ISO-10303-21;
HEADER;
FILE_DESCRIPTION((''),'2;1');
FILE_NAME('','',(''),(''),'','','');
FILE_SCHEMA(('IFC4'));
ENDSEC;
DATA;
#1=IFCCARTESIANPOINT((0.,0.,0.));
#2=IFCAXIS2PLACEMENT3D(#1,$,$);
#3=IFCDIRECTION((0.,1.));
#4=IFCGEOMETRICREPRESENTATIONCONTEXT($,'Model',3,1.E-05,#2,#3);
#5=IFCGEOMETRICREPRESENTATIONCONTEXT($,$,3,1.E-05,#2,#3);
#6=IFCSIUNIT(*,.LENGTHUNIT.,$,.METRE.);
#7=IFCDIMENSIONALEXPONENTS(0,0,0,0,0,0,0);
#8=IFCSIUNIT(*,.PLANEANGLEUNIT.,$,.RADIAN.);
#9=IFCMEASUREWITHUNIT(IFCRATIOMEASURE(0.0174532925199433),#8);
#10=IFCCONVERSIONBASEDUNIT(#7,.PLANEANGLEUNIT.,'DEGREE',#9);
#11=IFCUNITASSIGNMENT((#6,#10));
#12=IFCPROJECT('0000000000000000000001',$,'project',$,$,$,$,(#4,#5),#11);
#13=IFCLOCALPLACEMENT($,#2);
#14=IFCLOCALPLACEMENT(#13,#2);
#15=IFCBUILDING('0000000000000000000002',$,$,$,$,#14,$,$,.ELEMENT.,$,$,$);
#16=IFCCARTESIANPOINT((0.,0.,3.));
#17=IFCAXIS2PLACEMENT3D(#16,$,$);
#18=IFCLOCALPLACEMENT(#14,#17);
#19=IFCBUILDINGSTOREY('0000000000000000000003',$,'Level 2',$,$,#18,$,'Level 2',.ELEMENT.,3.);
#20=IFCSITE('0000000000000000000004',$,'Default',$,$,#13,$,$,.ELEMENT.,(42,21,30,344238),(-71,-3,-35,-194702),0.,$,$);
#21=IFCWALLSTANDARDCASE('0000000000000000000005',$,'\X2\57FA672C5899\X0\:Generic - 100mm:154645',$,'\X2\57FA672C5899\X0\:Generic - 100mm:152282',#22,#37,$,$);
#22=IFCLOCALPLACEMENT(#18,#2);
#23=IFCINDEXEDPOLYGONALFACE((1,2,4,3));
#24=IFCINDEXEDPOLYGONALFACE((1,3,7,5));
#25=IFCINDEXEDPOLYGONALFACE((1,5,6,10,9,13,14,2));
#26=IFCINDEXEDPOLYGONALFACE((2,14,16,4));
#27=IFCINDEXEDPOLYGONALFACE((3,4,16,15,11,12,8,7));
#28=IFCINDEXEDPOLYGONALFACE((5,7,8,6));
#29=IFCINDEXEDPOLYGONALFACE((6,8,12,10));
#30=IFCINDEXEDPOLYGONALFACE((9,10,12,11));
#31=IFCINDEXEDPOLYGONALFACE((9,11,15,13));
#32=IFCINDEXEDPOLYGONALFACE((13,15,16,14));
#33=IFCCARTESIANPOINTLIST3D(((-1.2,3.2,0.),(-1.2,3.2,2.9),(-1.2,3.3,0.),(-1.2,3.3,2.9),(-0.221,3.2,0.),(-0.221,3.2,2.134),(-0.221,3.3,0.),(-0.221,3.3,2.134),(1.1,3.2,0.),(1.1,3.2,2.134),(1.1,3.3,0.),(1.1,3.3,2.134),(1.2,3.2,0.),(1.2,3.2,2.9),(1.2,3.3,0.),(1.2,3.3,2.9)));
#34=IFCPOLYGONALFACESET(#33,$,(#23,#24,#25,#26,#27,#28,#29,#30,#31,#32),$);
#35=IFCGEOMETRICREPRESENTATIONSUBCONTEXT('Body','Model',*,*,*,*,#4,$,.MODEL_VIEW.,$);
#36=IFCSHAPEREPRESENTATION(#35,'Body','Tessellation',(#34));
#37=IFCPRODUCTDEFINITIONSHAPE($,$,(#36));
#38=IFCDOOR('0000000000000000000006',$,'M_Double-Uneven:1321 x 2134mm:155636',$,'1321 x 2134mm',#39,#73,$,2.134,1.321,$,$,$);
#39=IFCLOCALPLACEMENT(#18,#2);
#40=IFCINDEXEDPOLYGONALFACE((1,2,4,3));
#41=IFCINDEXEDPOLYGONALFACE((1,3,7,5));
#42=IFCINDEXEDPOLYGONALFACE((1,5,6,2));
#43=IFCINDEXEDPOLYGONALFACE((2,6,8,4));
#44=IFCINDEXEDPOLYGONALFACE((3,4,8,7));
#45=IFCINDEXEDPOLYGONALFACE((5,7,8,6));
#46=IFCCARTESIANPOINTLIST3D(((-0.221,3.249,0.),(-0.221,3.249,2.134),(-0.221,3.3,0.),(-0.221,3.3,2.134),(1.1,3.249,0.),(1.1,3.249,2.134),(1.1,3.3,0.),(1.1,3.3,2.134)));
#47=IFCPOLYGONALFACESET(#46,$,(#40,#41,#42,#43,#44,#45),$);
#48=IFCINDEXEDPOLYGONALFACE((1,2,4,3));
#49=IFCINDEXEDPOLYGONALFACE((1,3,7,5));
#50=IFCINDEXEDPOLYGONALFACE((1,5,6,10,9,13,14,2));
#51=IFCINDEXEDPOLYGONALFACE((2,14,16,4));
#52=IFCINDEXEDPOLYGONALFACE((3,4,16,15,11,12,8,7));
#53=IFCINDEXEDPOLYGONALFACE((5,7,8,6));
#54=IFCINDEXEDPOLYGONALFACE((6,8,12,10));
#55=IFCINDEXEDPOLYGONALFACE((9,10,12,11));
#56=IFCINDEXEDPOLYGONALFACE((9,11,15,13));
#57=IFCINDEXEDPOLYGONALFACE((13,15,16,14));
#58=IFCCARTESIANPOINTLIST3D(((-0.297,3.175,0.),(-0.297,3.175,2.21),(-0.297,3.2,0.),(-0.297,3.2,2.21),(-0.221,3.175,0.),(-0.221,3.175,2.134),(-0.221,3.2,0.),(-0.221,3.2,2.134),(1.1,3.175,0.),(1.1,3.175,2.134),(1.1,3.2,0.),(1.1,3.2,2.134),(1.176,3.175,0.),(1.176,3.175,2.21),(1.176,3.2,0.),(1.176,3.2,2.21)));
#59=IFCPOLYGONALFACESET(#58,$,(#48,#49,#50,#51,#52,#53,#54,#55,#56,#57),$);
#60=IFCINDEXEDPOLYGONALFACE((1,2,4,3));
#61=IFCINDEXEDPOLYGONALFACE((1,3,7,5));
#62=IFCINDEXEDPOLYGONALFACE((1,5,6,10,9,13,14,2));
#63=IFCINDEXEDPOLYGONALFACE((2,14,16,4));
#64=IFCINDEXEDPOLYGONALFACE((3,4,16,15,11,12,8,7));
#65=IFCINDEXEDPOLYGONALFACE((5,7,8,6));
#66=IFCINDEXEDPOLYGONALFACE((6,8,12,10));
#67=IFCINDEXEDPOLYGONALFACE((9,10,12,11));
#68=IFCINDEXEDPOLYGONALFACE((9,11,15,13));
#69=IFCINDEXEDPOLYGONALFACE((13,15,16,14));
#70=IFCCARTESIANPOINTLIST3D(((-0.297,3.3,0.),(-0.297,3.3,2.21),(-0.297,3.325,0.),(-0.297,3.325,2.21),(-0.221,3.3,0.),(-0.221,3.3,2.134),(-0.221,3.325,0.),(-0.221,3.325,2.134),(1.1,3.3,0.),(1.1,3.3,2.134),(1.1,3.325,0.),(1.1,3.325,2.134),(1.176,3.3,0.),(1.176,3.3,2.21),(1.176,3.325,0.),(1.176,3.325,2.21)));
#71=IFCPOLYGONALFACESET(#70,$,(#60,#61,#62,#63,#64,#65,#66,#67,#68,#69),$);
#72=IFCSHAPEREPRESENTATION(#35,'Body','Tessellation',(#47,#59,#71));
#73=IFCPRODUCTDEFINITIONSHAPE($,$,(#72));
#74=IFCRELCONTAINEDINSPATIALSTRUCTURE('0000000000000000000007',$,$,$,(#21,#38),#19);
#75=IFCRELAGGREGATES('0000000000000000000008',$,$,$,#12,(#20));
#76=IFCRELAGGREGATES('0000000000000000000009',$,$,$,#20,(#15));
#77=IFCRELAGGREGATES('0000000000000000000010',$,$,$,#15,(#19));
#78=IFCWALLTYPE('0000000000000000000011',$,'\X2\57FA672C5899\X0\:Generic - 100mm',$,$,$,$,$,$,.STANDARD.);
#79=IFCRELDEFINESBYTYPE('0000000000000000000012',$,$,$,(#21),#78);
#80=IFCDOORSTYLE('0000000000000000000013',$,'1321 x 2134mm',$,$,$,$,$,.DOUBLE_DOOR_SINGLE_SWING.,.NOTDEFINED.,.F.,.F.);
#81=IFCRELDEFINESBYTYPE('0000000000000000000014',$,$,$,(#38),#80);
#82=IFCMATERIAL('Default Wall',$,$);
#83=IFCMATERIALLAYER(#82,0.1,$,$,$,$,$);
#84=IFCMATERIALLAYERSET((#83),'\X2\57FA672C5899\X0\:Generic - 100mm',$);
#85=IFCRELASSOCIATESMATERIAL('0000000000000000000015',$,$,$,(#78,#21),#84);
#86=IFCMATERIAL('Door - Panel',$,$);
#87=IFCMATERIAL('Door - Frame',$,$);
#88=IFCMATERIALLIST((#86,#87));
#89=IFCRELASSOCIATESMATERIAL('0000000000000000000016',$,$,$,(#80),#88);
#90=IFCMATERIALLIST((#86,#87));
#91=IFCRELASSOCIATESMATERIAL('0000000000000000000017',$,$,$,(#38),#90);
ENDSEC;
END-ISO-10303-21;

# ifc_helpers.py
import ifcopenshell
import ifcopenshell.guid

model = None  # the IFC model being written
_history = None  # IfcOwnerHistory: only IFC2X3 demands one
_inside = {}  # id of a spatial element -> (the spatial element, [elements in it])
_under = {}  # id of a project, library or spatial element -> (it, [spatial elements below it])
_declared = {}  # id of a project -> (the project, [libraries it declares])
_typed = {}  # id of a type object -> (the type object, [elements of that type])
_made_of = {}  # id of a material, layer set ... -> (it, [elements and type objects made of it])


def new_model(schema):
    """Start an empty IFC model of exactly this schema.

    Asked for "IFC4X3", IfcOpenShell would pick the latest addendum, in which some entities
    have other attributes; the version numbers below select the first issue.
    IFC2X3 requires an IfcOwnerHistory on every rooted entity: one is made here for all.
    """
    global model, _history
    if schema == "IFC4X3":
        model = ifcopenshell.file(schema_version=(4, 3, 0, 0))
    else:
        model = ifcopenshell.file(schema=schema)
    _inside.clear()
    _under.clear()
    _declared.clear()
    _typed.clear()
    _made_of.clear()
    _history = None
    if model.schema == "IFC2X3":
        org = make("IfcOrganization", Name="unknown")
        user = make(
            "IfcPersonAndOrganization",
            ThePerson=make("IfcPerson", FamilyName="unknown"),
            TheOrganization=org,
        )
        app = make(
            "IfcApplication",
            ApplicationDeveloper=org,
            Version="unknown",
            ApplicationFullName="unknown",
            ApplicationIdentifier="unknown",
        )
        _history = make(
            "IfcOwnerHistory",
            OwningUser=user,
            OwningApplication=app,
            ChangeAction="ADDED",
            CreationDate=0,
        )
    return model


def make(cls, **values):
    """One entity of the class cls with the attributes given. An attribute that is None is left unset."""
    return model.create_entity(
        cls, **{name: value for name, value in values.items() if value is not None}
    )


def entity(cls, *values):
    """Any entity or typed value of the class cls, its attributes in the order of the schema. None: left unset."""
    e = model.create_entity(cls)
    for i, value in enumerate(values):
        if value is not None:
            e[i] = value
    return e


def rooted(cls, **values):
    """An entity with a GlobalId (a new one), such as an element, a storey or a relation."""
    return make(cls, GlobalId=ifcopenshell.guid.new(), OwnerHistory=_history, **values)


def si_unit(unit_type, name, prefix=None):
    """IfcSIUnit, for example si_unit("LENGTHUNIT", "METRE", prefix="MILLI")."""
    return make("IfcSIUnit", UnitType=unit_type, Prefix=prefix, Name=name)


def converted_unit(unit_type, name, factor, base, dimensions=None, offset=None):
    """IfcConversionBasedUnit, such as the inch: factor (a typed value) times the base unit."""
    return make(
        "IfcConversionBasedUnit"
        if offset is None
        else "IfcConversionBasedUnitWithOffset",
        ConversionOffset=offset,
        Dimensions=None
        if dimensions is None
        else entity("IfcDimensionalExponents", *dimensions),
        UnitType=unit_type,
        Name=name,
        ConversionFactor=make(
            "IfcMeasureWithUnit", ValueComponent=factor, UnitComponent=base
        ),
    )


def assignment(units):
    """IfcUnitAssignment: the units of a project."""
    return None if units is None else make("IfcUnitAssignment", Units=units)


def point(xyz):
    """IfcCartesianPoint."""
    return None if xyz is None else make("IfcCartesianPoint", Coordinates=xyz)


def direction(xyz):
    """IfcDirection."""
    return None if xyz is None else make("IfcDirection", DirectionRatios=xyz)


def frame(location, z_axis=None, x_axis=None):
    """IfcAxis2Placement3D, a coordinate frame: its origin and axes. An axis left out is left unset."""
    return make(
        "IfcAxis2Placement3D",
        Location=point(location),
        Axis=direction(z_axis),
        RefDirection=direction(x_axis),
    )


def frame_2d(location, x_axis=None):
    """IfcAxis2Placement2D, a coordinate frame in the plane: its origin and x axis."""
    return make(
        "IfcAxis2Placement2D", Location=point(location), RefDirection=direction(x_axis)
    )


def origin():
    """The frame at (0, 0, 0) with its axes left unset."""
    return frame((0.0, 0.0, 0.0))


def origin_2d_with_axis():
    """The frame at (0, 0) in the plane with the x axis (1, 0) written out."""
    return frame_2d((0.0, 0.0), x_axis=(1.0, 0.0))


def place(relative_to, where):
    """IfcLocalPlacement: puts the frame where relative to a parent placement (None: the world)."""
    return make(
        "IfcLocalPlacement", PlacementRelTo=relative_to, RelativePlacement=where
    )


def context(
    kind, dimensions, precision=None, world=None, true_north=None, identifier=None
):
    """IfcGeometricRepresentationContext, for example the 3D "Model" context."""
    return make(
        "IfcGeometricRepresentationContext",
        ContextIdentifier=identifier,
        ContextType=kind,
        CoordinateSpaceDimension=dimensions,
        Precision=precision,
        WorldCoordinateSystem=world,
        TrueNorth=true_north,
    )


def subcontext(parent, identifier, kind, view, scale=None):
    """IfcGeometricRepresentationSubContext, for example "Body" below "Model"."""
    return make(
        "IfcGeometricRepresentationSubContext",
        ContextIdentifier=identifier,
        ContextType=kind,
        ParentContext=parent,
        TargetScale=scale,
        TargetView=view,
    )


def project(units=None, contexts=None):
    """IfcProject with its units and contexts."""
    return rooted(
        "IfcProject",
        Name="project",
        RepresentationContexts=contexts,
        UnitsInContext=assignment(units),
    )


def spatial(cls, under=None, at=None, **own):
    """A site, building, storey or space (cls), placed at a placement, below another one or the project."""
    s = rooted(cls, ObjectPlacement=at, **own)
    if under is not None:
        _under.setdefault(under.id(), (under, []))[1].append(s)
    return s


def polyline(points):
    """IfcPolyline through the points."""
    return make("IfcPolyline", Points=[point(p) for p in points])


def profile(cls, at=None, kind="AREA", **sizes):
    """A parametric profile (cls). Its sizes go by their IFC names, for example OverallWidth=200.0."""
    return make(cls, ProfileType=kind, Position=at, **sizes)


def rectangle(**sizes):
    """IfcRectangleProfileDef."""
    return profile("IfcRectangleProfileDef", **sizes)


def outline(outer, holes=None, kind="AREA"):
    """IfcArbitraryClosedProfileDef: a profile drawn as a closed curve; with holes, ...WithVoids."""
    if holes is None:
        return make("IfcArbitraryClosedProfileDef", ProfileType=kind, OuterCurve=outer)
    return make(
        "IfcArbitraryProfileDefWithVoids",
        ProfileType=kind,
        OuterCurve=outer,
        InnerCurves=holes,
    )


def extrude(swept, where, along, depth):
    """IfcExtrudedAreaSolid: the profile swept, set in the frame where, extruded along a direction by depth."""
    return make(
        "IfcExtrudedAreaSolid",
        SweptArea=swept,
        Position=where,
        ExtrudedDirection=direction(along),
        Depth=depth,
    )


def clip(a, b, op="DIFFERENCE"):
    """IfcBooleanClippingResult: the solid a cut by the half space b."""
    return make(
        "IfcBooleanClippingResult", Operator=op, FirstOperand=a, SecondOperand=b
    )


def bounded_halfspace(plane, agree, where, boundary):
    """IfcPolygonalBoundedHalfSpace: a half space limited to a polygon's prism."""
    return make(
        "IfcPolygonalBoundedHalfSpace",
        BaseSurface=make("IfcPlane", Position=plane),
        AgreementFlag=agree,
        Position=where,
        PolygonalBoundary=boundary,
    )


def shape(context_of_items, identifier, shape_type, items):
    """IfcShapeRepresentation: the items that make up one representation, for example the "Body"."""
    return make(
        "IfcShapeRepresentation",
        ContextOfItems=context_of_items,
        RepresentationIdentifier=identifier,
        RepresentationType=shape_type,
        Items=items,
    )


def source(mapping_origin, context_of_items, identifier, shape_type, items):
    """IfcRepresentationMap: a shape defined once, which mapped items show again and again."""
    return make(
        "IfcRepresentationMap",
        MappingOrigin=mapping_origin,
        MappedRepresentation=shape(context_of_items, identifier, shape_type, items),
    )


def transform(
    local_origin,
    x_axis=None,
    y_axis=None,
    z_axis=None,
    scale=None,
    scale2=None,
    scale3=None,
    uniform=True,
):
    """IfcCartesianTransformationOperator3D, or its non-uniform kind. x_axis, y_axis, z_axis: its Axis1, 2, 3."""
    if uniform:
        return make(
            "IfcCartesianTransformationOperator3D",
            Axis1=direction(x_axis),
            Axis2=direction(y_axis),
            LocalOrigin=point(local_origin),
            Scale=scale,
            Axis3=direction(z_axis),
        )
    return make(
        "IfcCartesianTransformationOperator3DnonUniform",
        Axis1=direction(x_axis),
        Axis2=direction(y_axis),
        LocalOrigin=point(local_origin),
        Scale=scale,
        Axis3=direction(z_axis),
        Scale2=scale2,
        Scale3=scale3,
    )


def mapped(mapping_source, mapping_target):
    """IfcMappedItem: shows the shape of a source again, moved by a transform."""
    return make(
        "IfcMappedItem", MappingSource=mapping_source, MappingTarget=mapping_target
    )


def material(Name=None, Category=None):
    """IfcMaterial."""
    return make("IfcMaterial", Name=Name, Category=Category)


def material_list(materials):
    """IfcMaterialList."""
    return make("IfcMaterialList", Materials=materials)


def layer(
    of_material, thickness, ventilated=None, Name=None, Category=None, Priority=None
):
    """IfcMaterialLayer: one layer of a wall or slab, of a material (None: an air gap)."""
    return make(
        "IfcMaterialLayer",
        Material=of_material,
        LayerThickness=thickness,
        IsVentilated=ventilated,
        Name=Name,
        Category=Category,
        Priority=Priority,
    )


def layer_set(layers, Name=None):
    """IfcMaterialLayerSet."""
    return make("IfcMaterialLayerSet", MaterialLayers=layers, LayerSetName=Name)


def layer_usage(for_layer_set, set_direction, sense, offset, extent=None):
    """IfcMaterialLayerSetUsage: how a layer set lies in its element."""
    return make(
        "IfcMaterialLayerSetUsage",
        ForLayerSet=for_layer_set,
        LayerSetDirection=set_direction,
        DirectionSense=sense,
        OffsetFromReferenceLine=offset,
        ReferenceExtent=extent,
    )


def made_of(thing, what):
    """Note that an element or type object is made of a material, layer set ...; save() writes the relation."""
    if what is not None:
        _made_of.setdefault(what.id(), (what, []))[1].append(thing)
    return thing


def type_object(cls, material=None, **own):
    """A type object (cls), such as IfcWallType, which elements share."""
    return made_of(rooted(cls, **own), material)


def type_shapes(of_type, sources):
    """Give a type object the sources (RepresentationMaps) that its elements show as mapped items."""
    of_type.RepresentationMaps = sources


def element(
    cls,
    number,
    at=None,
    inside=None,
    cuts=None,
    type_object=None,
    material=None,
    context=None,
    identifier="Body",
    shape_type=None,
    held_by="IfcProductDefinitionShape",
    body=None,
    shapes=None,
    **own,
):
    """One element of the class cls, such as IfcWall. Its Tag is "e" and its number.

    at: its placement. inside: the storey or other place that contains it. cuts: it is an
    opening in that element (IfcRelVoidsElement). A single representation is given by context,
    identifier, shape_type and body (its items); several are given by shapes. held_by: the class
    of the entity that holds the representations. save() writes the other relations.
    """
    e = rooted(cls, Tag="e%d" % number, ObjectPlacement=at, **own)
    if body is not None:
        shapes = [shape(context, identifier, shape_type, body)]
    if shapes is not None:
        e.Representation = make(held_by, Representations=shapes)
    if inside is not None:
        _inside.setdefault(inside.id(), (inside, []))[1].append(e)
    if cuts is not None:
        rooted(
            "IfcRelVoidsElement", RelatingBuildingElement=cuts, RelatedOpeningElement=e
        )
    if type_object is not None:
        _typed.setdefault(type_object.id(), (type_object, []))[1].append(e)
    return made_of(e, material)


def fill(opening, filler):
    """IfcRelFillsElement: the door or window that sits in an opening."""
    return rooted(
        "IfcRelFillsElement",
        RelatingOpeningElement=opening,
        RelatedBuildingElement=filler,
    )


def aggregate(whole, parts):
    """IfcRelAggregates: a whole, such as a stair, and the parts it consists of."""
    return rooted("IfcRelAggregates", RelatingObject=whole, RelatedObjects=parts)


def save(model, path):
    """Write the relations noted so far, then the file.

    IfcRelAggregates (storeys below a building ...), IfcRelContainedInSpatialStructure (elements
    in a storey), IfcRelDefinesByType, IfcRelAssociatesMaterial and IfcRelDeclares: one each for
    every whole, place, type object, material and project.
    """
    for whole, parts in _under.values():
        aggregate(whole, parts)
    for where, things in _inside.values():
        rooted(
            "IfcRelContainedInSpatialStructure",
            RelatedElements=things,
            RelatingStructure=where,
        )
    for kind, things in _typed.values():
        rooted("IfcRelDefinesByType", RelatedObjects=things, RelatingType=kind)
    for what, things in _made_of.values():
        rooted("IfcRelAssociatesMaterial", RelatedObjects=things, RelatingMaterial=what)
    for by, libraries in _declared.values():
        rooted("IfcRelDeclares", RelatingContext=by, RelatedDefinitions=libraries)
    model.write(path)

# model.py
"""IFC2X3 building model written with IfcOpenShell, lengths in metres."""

from ifc_helpers import new_model, entity, si_unit, converted_unit, direction, frame, frame_2d, origin, origin_2d_with_axis, place, context, subcontext, project, spatial, polyline, rectangle, outline, extrude, clip, bounded_halfspace, source, transform, mapped, material, material_list, layer, layer_set, layer_usage, type_object, type_shapes, element, fill, save


model = new_model("IFC2X3")

# Units and contexts
model_context = context("Model", 3, precision=1e-05, world=origin(), true_north=direction((0.0, 1.0)))
context_of_model = context(None, 3, precision=1e-05, world=origin(), true_north=direction((0.0, 1.0)))
body_context = subcontext(model_context, "Body", "Model", "MODEL_VIEW")
ifc_project = project(units=[si_unit("LENGTHUNIT", "METRE"), converted_unit("PLANEANGLEUNIT", "DEGREE", entity("IfcRatioMeasure", 0.0174532925199433), si_unit("PLANEANGLEUNIT", "RADIAN"), dimensions=[0, 0, 0, 0, 0, 0, 0])], contexts=[model_context, context_of_model])

# Site, building, storey
site_placement = place(None, origin())
site = spatial("IfcSite", under=ifc_project, at=site_placement, Name="Default", CompositionType="ELEMENT", RefLatitude=(42, 21, 30, 344238), RefLongitude=(-71, -3, -35, -194702), RefElevation=0.0)
building_placement = place(site_placement, origin())
building = spatial("IfcBuilding", under=site, at=building_placement, CompositionType="ELEMENT")
storey_placement = place(building_placement, frame((0.0, 0.0, 3.0)))
storey = spatial("IfcBuildingStorey", under=building, at=storey_placement, Name="Level 2", LongName="Level 2", CompositionType="ELEMENT", Elevation=3.0)

# Shared definitions
ifc_material_1 = material(Name="Default Wall")
ifc_material_2 = material(Name="Door - Panel")
ifc_material_3 = material(Name="Door - Frame")

# Shared definitions
ifc_layer_1 = layer(ifc_material_1, 0.1)
ifc_layer_set_1 = layer_set([ifc_layer_1], Name="基本墙:Generic - 100mm")
wall_type_1 = type_object("IfcWallType", Name="基本墙:Generic - 100mm", PredefinedType="STANDARD", material=ifc_layer_set_1)

# Wall, opening, door
ifc_layer_usage_1 = layer_usage(ifc_layer_set_1, "AXIS2", "NEGATIVE", 0.05)
wall_1_placement = place(storey_placement, frame((-1.2, 3.25, 0.0)))
wall_1 = element("IfcWallStandardCase", 1, at=wall_1_placement, inside=storey, type_object=wall_type_1, material=ifc_layer_usage_1, Name="基本墙:Generic - 100mm:154645", ObjectType="基本墙:Generic - 100mm:152282", context=body_context, shape_type="Clipping", body=[
    clip(extrude(rectangle(XDim=2.4, YDim=0.1, at=frame_2d((1.2, 0.0), x_axis=(-1.0, 0.0))), origin(), (0.0, 0.0, 1.0), 3.2), bounded_halfspace(frame((0.0, -0.05, 2.9), z_axis=(0.0, 0.0, -1.0), x_axis=(0.0, -1.0, 0.0)), True, frame((0.0, -0.05, 2.9), z_axis=(0.0, 0.0, -1.0), x_axis=(0.0, -1.0, 0.0)), polyline([(0.0, 0.0), (-0.1, 0.0), (-0.1, -0.779), (-0.1, -0.879), (-0.1, -2.4), (0.0, -2.4), (0.0, 0.0)]))),
])
opening_1_placement = place(wall_1_placement, frame((0.979, -0.05, 0.0)))
opening_1 = element("IfcOpeningElement", 2, at=opening_1_placement, cuts=wall_1, ObjectType="Opening", context=body_context, shape_type="SweptSolid", body=[
    extrude(rectangle(XDim=2.134, YDim=1.321, at=frame_2d((1.067, 0.6605), x_axis=(1.0, 0.0))), frame((0.0, 0.0, 0.0), z_axis=(0.0, 1.0, 0.0), x_axis=(0.0, 0.0, 1.0)), (0.0, 0.0, 1.0), 0.1),
])
ifc_material_list_1 = material_list([ifc_material_2, ifc_material_3])
ifc_material_list_2 = material_list([ifc_material_2, ifc_material_3])
door_style_1 = type_object("IfcDoorStyle", Name="1321 x 2134mm", ConstructionType="NOTDEFINED", OperationType="DOUBLE_DOOR_SINGLE_SWING", ParameterTakesPrecedence=False, Sizeable=False, material=ifc_material_list_2)
shared_shape_1 = source(origin(), body_context, "Body", "SweptSolid", [
    extrude(rectangle(XDim=0.051, YDim=1.321, at=origin_2d_with_axis()), frame((1.7775, 0.0745, 0.0), z_axis=(0.0, 0.0, 1.0), x_axis=(0.0, -1.0, 0.0)), (0.0, 0.0, 1.0), 2.134),
    extrude(outline(polyline([(-1.048, 0.6605), (1.086, 0.6605), (1.086, 0.7365), (-1.124, 0.7365), (-1.124, -0.7365), (1.086, -0.7365), (1.086, -0.6605), (-1.048, -0.6605), (-1.048, 0.6605)])), frame((1.7775, 0.0, 1.086), z_axis=(0.0, -1.0, 0.0), x_axis=(0.0, 0.0, -1.0)), (0.0, 0.0, 1.0), 0.025),
    extrude(outline(polyline([(-1.048, 0.6605), (1.086, 0.6605), (1.086, 0.7365), (-1.124, 0.7365), (-1.124, -0.7365), (1.086, -0.7365), (1.086, -0.6605), (-1.048, -0.6605), (-1.048, 0.6605)])), frame((1.7775, 0.125, 1.086), z_axis=(0.0, -1.0, 0.0), x_axis=(0.0, 0.0, -1.0)), (0.0, 0.0, 1.0), 0.025),
])
type_shapes(door_style_1, [shared_shape_1])
door_1_placement = place(opening_1_placement, frame((-1.117, 0.0, 0.0)))
door_1 = element("IfcDoor", 3, at=door_1_placement, inside=storey, type_object=door_style_1, material=ifc_material_list_1, Name="M_Double-Uneven:1321 x 2134mm:155636", ObjectType="1321 x 2134mm", OverallHeight=2.134, OverallWidth=1.321, context=body_context, shape_type="MappedRepresentation", body=[
    mapped(shared_shape_1, transform((0.0, 0.0, 0.0), scale=1.0)),
])
fill(opening_1, door_1)

save(model, "model.ifc")
